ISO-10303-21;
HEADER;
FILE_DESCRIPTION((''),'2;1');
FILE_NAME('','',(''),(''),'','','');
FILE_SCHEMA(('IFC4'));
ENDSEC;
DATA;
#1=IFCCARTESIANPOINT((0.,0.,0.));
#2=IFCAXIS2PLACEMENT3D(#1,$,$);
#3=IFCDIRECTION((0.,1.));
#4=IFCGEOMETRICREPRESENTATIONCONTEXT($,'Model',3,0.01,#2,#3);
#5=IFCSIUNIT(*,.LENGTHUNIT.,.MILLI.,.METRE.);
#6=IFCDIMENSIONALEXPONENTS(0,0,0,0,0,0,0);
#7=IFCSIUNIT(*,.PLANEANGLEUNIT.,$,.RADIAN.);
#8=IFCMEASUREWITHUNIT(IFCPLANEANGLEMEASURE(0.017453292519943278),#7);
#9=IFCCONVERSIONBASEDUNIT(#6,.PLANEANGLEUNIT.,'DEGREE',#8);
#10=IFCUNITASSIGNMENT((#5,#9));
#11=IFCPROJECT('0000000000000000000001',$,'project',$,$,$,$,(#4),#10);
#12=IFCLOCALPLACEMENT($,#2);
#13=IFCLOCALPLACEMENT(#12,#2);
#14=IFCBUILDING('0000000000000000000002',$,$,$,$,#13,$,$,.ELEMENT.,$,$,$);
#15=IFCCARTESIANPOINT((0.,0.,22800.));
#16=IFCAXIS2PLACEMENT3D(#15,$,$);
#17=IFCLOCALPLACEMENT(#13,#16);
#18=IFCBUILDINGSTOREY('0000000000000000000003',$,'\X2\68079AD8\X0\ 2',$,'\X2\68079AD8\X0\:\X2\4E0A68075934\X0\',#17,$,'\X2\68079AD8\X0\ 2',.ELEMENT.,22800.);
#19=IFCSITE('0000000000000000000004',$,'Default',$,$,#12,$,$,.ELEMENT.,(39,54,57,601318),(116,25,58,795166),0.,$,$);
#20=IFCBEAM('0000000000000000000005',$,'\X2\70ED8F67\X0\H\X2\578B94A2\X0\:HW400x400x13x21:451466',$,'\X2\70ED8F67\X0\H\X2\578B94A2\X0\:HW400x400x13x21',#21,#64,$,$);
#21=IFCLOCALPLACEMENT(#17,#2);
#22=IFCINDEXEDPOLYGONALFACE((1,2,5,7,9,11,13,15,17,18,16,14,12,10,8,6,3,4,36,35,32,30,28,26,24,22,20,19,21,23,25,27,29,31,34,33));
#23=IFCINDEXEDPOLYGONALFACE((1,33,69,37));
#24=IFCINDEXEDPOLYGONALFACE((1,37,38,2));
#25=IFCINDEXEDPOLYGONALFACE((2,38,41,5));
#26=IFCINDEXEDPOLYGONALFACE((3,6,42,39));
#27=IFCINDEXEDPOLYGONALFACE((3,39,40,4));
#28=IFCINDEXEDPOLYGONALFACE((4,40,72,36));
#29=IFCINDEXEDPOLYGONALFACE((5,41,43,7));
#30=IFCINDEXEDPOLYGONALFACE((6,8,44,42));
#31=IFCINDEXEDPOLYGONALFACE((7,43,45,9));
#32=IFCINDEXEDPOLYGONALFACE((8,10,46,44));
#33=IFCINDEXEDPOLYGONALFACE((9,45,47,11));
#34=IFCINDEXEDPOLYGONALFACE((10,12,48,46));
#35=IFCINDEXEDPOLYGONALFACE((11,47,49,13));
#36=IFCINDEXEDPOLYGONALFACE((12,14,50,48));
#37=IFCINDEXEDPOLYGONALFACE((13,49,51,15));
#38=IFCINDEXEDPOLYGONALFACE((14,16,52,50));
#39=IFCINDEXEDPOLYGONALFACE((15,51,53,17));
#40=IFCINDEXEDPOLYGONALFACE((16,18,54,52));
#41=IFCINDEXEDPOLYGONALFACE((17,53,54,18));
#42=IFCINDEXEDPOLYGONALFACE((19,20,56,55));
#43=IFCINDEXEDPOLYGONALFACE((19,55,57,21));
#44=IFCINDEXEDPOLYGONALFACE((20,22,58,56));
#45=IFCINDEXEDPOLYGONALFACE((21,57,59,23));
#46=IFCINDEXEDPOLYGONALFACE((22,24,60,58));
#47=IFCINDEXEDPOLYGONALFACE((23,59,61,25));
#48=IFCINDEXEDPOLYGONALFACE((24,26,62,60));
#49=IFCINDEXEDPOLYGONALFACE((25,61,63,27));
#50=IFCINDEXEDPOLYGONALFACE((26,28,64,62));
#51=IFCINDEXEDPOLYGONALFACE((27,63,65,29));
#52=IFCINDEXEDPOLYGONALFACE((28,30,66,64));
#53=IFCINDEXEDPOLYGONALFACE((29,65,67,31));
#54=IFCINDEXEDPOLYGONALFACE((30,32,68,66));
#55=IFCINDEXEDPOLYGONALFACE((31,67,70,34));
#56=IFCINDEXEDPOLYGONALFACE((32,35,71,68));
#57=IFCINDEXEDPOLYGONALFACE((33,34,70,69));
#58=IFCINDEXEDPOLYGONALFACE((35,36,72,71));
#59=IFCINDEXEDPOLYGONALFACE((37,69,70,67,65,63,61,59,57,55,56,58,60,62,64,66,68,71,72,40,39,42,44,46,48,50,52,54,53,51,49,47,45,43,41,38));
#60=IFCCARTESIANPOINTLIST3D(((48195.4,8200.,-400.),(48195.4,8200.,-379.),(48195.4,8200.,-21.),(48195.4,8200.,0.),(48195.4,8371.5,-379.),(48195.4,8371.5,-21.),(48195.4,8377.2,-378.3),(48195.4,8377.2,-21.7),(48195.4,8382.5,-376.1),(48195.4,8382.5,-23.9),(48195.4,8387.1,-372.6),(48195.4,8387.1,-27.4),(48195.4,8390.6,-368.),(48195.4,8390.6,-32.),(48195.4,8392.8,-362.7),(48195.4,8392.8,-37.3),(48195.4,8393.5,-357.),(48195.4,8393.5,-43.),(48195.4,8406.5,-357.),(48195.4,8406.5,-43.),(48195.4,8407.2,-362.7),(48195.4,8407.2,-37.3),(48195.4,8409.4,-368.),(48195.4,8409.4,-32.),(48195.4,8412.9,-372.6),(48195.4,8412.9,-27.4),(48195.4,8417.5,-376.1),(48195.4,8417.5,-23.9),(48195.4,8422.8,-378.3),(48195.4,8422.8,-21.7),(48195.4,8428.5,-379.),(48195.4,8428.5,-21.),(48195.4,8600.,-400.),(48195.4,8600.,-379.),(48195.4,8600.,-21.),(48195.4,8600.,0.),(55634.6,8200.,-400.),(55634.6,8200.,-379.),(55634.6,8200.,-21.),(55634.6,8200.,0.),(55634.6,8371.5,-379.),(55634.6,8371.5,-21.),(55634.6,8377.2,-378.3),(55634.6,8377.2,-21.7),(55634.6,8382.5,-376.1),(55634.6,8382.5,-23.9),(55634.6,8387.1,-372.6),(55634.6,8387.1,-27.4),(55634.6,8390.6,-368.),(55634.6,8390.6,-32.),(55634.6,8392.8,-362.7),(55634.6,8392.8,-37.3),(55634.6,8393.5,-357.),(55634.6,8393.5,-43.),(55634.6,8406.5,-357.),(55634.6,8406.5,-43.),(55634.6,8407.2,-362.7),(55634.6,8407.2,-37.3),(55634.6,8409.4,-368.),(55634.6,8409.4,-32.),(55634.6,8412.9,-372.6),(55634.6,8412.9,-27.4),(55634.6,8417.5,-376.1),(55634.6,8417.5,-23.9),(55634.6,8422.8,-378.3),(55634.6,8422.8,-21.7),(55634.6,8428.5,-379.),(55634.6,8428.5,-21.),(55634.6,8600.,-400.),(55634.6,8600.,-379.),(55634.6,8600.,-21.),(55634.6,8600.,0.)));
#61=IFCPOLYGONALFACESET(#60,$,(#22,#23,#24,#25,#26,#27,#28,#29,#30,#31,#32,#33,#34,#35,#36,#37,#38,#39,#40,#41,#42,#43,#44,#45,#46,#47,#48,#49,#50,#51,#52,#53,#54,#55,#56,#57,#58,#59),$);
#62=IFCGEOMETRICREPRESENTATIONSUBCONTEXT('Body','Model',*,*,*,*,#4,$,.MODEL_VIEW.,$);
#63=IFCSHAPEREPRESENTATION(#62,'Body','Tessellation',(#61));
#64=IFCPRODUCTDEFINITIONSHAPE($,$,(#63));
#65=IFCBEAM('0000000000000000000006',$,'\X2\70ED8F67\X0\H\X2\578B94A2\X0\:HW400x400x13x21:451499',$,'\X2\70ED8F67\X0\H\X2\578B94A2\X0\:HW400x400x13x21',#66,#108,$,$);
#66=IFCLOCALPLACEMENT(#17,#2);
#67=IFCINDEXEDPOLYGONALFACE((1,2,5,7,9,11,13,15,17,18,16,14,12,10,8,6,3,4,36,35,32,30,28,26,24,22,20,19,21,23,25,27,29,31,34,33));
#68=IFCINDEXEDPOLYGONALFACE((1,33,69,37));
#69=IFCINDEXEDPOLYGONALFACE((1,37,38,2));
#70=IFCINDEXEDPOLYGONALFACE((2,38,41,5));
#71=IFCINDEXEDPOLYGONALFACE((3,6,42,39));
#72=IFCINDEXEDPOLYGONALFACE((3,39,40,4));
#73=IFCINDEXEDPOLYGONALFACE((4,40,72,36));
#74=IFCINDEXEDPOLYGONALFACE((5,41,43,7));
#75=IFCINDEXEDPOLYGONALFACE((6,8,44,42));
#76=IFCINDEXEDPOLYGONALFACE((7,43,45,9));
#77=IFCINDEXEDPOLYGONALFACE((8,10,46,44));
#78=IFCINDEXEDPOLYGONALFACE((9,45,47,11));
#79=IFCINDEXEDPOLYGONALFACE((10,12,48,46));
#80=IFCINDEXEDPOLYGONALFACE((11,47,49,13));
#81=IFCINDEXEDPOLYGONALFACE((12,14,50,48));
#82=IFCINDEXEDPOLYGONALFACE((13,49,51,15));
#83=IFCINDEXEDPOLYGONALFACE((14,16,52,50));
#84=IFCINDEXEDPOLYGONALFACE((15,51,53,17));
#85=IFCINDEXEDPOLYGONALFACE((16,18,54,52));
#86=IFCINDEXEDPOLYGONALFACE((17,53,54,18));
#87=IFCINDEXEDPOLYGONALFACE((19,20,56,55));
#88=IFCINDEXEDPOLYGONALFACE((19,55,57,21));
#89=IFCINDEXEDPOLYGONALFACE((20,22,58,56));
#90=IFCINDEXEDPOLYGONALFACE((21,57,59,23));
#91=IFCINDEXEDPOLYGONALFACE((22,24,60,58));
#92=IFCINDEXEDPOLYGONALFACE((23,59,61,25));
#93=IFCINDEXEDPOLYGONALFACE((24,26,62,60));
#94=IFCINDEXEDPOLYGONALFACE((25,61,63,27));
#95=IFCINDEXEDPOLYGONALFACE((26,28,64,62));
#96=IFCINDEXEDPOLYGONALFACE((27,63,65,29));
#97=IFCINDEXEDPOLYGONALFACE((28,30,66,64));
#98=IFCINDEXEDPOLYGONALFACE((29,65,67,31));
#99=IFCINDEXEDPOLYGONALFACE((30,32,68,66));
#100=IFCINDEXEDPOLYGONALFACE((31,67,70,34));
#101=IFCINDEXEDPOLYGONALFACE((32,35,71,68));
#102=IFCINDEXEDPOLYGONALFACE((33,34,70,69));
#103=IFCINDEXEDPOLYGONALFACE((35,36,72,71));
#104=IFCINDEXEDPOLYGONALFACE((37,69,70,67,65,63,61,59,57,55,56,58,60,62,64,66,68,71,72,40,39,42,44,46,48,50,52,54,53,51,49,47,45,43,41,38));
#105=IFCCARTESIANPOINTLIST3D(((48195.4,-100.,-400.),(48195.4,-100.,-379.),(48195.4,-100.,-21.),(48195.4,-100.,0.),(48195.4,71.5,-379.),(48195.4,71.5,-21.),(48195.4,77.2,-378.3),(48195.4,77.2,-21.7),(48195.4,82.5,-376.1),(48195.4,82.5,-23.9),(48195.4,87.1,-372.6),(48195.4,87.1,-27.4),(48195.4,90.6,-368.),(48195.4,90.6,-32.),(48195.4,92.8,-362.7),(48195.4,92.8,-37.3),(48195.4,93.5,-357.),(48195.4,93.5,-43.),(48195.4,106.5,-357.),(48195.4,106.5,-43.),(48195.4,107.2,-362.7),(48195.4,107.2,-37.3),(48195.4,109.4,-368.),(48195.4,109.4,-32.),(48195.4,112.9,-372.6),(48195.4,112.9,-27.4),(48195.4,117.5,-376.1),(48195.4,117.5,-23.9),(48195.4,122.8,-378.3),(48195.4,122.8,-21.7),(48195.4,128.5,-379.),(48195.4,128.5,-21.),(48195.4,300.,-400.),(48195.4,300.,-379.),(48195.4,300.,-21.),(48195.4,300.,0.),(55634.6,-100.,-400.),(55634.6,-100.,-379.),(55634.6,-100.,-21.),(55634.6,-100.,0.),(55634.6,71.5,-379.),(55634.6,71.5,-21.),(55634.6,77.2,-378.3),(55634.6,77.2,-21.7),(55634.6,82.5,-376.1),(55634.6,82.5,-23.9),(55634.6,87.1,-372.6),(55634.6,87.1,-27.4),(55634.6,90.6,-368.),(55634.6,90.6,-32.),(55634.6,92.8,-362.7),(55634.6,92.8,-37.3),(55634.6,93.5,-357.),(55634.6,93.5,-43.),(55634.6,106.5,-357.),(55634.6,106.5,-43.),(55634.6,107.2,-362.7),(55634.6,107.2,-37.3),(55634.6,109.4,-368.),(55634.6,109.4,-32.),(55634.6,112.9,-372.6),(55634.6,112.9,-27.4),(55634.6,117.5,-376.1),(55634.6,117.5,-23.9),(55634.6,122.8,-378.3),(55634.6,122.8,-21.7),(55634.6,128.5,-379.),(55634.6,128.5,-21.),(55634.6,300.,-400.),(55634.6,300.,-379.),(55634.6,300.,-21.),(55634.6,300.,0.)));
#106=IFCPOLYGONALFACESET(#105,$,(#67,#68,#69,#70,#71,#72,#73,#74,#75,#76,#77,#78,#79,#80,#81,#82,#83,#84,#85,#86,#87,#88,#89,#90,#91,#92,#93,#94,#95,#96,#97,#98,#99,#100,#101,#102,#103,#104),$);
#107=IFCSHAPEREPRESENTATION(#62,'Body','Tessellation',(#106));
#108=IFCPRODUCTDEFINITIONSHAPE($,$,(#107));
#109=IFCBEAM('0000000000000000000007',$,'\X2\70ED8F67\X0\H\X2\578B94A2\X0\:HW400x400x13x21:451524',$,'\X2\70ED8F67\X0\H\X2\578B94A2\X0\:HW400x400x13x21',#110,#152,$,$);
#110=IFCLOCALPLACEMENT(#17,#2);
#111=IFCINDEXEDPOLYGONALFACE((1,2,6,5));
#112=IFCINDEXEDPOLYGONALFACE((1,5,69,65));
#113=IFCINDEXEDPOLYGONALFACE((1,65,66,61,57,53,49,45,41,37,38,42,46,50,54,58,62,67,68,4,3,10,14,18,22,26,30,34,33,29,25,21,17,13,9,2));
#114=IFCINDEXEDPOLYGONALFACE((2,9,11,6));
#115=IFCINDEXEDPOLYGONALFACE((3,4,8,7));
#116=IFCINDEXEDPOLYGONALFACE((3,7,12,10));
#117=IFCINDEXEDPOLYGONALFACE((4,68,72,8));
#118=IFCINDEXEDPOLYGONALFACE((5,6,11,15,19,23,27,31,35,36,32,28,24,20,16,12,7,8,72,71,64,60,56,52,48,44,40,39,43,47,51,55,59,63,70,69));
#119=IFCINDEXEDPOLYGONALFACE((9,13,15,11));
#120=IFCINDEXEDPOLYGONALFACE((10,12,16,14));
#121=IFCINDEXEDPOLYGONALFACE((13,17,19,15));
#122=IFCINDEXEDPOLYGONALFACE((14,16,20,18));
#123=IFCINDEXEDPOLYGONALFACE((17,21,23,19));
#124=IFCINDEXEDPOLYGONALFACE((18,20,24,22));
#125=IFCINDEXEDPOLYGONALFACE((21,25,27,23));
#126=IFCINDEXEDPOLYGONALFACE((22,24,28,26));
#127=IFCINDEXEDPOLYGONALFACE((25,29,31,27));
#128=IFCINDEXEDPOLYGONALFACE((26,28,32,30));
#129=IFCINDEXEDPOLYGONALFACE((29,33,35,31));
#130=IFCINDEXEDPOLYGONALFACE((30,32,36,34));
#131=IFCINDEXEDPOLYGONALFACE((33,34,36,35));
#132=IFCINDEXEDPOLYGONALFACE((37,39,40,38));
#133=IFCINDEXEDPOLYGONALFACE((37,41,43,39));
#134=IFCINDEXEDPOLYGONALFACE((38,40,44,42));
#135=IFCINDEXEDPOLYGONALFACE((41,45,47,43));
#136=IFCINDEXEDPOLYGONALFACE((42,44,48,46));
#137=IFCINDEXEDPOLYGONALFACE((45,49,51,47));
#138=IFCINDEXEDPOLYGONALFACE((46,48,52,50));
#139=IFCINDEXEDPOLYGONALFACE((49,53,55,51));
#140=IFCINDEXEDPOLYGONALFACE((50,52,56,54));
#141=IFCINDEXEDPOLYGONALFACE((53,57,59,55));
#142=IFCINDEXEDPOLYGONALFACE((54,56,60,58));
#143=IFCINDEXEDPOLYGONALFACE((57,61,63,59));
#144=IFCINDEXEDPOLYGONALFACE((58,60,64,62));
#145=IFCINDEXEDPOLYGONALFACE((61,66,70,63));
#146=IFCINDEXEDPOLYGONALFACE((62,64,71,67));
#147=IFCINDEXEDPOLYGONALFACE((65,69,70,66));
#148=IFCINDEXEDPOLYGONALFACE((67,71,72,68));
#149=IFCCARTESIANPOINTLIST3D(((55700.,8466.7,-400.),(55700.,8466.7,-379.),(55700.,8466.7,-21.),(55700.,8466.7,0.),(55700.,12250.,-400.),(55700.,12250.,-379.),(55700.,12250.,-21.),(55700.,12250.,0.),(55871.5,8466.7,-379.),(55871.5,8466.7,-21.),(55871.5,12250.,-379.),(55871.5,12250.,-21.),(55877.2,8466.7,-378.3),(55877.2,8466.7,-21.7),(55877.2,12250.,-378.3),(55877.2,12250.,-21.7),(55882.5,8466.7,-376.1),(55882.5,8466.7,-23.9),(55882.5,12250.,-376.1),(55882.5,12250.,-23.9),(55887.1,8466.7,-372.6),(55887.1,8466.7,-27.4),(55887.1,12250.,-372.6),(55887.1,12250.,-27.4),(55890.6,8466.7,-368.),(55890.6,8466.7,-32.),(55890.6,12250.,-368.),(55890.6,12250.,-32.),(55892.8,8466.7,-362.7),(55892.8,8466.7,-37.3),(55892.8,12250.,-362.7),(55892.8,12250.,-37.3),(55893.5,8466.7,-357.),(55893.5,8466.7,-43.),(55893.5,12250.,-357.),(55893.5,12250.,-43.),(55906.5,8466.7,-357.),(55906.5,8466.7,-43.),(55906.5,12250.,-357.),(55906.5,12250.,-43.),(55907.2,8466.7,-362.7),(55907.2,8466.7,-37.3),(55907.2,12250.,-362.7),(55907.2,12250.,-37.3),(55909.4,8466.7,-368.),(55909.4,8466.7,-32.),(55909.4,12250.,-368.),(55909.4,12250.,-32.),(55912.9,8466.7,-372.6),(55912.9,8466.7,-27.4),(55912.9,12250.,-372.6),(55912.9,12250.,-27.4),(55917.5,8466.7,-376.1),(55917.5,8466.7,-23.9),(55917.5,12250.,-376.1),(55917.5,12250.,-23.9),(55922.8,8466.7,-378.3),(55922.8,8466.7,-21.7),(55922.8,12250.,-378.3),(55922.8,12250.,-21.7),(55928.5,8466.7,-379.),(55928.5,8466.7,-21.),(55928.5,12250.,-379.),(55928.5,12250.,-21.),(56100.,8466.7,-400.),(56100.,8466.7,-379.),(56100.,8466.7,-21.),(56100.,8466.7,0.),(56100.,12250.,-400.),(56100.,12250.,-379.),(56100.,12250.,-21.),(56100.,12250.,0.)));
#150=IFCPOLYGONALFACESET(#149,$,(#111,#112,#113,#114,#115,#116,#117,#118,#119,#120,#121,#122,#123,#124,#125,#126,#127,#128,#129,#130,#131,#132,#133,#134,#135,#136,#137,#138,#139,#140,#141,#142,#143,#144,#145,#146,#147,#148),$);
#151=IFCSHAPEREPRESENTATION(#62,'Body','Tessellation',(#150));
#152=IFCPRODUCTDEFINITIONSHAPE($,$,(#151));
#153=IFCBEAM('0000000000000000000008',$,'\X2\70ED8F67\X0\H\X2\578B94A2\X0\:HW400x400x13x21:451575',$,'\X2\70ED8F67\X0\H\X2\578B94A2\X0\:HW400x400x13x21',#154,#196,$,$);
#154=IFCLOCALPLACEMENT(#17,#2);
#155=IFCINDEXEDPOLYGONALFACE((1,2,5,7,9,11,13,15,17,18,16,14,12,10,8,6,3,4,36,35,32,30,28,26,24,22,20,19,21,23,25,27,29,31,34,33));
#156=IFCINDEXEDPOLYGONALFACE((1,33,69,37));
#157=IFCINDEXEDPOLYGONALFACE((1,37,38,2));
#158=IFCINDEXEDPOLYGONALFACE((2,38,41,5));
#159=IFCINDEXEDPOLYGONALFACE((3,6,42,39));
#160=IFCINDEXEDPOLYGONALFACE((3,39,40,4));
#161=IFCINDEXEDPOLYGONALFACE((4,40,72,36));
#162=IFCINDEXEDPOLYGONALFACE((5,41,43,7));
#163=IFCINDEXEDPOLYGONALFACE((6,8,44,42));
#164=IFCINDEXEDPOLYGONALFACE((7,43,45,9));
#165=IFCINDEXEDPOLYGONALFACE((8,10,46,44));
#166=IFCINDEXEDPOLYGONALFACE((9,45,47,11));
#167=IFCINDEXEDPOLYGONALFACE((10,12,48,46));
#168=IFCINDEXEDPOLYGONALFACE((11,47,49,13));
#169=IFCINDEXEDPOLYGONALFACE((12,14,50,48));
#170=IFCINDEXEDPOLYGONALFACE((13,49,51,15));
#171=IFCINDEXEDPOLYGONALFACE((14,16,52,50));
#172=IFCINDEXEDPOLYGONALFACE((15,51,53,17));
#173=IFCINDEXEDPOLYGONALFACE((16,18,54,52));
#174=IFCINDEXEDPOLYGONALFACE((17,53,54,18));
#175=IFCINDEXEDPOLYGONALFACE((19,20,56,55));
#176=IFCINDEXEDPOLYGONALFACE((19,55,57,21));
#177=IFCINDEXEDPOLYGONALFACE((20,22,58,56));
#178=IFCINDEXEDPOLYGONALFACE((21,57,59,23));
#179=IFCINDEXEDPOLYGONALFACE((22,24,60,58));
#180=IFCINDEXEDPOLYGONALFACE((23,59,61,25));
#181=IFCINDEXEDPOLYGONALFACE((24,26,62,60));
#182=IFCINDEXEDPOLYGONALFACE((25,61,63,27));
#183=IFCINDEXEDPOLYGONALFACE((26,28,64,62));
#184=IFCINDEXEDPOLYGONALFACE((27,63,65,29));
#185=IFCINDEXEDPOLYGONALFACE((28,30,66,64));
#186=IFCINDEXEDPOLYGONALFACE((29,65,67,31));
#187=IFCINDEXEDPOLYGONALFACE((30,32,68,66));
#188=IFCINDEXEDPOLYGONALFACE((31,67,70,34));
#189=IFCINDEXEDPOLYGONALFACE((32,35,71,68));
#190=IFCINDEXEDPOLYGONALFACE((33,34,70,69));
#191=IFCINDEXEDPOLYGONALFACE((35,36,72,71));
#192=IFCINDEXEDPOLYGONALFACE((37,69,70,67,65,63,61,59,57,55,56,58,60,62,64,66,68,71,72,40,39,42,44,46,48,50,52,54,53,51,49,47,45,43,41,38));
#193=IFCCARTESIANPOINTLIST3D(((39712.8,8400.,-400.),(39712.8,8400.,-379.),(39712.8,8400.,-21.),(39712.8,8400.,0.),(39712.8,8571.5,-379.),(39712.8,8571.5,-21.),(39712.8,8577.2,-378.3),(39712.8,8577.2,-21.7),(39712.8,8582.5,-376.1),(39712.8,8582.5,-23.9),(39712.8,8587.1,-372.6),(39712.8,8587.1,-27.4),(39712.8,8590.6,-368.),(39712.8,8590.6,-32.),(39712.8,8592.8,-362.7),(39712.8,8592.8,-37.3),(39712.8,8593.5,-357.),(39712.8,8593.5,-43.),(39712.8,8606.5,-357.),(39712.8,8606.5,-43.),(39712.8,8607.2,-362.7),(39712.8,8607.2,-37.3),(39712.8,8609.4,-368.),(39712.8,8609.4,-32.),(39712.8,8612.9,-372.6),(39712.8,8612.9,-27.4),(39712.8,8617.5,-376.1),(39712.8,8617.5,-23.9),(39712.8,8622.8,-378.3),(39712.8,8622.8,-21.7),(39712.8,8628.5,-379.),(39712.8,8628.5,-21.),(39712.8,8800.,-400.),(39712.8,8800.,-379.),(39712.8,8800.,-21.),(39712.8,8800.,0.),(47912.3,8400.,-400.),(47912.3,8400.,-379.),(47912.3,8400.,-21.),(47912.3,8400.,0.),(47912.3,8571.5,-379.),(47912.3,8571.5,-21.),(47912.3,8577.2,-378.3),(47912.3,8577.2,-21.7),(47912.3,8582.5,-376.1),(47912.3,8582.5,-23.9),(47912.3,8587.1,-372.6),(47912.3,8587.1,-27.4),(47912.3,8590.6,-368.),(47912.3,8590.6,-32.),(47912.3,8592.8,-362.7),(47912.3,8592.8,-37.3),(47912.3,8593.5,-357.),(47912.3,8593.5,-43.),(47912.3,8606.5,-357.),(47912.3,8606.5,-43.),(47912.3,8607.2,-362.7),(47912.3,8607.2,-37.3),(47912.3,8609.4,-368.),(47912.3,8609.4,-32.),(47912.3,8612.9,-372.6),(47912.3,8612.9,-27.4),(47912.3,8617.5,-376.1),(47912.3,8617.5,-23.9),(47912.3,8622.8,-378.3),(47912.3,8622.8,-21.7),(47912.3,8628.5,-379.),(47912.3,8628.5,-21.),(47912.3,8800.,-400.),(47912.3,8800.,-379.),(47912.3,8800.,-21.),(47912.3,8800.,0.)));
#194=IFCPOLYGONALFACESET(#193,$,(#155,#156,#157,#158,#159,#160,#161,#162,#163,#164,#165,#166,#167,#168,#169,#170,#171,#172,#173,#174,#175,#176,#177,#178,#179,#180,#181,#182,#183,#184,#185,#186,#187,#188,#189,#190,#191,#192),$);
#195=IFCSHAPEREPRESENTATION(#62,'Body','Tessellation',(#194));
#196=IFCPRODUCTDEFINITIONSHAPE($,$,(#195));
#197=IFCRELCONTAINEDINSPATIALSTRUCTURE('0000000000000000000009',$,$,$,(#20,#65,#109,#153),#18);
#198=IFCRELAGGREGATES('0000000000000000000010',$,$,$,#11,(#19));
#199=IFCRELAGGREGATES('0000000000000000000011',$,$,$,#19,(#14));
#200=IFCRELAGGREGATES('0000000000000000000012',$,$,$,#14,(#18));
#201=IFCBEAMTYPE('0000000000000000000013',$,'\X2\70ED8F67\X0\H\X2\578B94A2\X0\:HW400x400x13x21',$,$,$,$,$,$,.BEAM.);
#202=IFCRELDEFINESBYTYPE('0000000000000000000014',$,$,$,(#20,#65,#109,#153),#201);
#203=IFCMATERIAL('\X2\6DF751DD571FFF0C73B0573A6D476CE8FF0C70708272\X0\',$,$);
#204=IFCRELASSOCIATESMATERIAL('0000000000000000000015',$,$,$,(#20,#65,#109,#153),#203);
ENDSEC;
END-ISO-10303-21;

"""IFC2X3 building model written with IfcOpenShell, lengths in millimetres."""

from ifc_helpers import new_model, entity, si_unit, converted_unit, direction, frame, frame_2d, origin, place, context, subcontext, project, spatial, i_section, extrude, material, type_object, element, save


model = new_model("IFC2X3")

# Units and contexts
model_context = context("Model", 3, precision=0.01, world=origin(), true_north=direction((0.0, 1.0)))
body_context = subcontext(model_context, "Body", "Model", "MODEL_VIEW")
ifc_project = project(units=[si_unit("LENGTHUNIT", "METRE", prefix="MILLI"), converted_unit("PLANEANGLEUNIT", "DEGREE", entity("IfcPlaneAngleMeasure", 0.017453292519943278), si_unit("PLANEANGLEUNIT", "RADIAN"), dimensions=[0, 0, 0, 0, 0, 0, 0])], contexts=[model_context])

# Site, building, storey
site_placement = place(None, origin())
site = spatial("IfcSite", under=ifc_project, at=site_placement, Name="Default", CompositionType="ELEMENT", RefLatitude=(39, 54, 57, 601318), RefLongitude=(116, 25, 58, 795166), RefElevation=0.0)
building_placement = place(site_placement, origin())
building = spatial("IfcBuilding", under=site, at=building_placement, CompositionType="ELEMENT")
storey_placement = place(building_placement, frame((0.0, 0.0, 22800.0)))
storey = spatial("IfcBuildingStorey", under=building, at=storey_placement, Name="标高 2", ObjectType="标高:上标头", LongName="标高 2", CompositionType="ELEMENT", Elevation=22800.0)

# Beams
ifc_material = material(Name="混凝土，现场浇注，灰色")
beam_type = type_object("IfcBeamType", Name="热轧H型钢:HW400x400x13x21", PredefinedType="BEAM")
beam_1_placement = place(storey_placement, frame((55900.0, 8400.0, 0.0), z_axis=(0.0, 0.0, 1.0), x_axis=(-1.0, 0.0, 0.0)))
element("IfcBeam", 1, at=beam_1_placement, inside=storey, type_object=beam_type, material=ifc_material, Name="热轧H型钢:HW400x400x13x21:451466", ObjectType="热轧H型钢:HW400x400x13x21", context=body_context, shape_type="SweptSolid", body=[
    extrude(i_section(OverallWidth=400.0, OverallDepth=400.0, WebThickness=13.0, FlangeThickness=21.0, FilletRadius=22.0, at=frame_2d((0.0, 0.0), x_axis=(0.0, 1.0))), frame((265.4, 0.0, -200.0), z_axis=(1.0, 0.0, 0.0), x_axis=(0.0, 0.0, -1.0)), (0.0, 0.0, 1.0), 7439.2),
])
beam_2_placement = place(storey_placement, frame((48125.0, 100.0, 0.0)))
element("IfcBeam", 2, at=beam_2_placement, inside=storey, type_object=beam_type, material=ifc_material, Name="热轧H型钢:HW400x400x13x21:451499", ObjectType="热轧H型钢:HW400x400x13x21", context=body_context, shape_type="SweptSolid", body=[
    extrude(i_section(OverallWidth=400.0, OverallDepth=400.0, WebThickness=13.0, FlangeThickness=21.0, FilletRadius=22.0, at=frame_2d((0.0, 0.0), x_axis=(0.0, 1.0))), frame((70.4, 0.0, -200.0), z_axis=(1.0, 0.0, 0.0), x_axis=(0.0, 0.0, -1.0)), (0.0, 0.0, 1.0), 7439.2),
])
beam_3_placement = place(storey_placement, frame((55900.0, 8400.0, 0.0), z_axis=(0.0, 0.0, 1.0), x_axis=(0.0, 1.0, 0.0)))
element("IfcBeam", 3, at=beam_3_placement, inside=storey, type_object=beam_type, material=ifc_material, Name="热轧H型钢:HW400x400x13x21:451524", ObjectType="热轧H型钢:HW400x400x13x21", context=body_context, shape_type="SweptSolid", body=[
    extrude(i_section(OverallWidth=400.0, OverallDepth=400.0, WebThickness=13.0, FlangeThickness=21.0, FilletRadius=22.0, at=frame_2d((0.0, 0.0), x_axis=(0.0, 1.0))), frame((66.7, 0.0, -200.0), z_axis=(1.0, 0.0, 0.0), x_axis=(0.0, 0.0, -1.0)), (0.0, 0.0, 1.0), 3783.3),
])
beam_4_placement = place(storey_placement, frame((39700.0, 8600.0, 0.0)))
element("IfcBeam", 4, at=beam_4_placement, inside=storey, type_object=beam_type, material=ifc_material, Name="热轧H型钢:HW400x400x13x21:451575", ObjectType="热轧H型钢:HW400x400x13x21", context=body_context, shape_type="SweptSolid", body=[
    extrude(i_section(OverallWidth=400.0, OverallDepth=400.0, WebThickness=13.0, FlangeThickness=21.0, FilletRadius=22.0, at=frame_2d((0.0, 0.0), x_axis=(0.0, 1.0))), frame((12.8, 0.0, -200.0), z_axis=(1.0, 0.0, 0.0), x_axis=(0.0, 0.0, -1.0)), (0.0, 0.0, 1.0), 8199.5),
])

save(model, "model.ifc")
